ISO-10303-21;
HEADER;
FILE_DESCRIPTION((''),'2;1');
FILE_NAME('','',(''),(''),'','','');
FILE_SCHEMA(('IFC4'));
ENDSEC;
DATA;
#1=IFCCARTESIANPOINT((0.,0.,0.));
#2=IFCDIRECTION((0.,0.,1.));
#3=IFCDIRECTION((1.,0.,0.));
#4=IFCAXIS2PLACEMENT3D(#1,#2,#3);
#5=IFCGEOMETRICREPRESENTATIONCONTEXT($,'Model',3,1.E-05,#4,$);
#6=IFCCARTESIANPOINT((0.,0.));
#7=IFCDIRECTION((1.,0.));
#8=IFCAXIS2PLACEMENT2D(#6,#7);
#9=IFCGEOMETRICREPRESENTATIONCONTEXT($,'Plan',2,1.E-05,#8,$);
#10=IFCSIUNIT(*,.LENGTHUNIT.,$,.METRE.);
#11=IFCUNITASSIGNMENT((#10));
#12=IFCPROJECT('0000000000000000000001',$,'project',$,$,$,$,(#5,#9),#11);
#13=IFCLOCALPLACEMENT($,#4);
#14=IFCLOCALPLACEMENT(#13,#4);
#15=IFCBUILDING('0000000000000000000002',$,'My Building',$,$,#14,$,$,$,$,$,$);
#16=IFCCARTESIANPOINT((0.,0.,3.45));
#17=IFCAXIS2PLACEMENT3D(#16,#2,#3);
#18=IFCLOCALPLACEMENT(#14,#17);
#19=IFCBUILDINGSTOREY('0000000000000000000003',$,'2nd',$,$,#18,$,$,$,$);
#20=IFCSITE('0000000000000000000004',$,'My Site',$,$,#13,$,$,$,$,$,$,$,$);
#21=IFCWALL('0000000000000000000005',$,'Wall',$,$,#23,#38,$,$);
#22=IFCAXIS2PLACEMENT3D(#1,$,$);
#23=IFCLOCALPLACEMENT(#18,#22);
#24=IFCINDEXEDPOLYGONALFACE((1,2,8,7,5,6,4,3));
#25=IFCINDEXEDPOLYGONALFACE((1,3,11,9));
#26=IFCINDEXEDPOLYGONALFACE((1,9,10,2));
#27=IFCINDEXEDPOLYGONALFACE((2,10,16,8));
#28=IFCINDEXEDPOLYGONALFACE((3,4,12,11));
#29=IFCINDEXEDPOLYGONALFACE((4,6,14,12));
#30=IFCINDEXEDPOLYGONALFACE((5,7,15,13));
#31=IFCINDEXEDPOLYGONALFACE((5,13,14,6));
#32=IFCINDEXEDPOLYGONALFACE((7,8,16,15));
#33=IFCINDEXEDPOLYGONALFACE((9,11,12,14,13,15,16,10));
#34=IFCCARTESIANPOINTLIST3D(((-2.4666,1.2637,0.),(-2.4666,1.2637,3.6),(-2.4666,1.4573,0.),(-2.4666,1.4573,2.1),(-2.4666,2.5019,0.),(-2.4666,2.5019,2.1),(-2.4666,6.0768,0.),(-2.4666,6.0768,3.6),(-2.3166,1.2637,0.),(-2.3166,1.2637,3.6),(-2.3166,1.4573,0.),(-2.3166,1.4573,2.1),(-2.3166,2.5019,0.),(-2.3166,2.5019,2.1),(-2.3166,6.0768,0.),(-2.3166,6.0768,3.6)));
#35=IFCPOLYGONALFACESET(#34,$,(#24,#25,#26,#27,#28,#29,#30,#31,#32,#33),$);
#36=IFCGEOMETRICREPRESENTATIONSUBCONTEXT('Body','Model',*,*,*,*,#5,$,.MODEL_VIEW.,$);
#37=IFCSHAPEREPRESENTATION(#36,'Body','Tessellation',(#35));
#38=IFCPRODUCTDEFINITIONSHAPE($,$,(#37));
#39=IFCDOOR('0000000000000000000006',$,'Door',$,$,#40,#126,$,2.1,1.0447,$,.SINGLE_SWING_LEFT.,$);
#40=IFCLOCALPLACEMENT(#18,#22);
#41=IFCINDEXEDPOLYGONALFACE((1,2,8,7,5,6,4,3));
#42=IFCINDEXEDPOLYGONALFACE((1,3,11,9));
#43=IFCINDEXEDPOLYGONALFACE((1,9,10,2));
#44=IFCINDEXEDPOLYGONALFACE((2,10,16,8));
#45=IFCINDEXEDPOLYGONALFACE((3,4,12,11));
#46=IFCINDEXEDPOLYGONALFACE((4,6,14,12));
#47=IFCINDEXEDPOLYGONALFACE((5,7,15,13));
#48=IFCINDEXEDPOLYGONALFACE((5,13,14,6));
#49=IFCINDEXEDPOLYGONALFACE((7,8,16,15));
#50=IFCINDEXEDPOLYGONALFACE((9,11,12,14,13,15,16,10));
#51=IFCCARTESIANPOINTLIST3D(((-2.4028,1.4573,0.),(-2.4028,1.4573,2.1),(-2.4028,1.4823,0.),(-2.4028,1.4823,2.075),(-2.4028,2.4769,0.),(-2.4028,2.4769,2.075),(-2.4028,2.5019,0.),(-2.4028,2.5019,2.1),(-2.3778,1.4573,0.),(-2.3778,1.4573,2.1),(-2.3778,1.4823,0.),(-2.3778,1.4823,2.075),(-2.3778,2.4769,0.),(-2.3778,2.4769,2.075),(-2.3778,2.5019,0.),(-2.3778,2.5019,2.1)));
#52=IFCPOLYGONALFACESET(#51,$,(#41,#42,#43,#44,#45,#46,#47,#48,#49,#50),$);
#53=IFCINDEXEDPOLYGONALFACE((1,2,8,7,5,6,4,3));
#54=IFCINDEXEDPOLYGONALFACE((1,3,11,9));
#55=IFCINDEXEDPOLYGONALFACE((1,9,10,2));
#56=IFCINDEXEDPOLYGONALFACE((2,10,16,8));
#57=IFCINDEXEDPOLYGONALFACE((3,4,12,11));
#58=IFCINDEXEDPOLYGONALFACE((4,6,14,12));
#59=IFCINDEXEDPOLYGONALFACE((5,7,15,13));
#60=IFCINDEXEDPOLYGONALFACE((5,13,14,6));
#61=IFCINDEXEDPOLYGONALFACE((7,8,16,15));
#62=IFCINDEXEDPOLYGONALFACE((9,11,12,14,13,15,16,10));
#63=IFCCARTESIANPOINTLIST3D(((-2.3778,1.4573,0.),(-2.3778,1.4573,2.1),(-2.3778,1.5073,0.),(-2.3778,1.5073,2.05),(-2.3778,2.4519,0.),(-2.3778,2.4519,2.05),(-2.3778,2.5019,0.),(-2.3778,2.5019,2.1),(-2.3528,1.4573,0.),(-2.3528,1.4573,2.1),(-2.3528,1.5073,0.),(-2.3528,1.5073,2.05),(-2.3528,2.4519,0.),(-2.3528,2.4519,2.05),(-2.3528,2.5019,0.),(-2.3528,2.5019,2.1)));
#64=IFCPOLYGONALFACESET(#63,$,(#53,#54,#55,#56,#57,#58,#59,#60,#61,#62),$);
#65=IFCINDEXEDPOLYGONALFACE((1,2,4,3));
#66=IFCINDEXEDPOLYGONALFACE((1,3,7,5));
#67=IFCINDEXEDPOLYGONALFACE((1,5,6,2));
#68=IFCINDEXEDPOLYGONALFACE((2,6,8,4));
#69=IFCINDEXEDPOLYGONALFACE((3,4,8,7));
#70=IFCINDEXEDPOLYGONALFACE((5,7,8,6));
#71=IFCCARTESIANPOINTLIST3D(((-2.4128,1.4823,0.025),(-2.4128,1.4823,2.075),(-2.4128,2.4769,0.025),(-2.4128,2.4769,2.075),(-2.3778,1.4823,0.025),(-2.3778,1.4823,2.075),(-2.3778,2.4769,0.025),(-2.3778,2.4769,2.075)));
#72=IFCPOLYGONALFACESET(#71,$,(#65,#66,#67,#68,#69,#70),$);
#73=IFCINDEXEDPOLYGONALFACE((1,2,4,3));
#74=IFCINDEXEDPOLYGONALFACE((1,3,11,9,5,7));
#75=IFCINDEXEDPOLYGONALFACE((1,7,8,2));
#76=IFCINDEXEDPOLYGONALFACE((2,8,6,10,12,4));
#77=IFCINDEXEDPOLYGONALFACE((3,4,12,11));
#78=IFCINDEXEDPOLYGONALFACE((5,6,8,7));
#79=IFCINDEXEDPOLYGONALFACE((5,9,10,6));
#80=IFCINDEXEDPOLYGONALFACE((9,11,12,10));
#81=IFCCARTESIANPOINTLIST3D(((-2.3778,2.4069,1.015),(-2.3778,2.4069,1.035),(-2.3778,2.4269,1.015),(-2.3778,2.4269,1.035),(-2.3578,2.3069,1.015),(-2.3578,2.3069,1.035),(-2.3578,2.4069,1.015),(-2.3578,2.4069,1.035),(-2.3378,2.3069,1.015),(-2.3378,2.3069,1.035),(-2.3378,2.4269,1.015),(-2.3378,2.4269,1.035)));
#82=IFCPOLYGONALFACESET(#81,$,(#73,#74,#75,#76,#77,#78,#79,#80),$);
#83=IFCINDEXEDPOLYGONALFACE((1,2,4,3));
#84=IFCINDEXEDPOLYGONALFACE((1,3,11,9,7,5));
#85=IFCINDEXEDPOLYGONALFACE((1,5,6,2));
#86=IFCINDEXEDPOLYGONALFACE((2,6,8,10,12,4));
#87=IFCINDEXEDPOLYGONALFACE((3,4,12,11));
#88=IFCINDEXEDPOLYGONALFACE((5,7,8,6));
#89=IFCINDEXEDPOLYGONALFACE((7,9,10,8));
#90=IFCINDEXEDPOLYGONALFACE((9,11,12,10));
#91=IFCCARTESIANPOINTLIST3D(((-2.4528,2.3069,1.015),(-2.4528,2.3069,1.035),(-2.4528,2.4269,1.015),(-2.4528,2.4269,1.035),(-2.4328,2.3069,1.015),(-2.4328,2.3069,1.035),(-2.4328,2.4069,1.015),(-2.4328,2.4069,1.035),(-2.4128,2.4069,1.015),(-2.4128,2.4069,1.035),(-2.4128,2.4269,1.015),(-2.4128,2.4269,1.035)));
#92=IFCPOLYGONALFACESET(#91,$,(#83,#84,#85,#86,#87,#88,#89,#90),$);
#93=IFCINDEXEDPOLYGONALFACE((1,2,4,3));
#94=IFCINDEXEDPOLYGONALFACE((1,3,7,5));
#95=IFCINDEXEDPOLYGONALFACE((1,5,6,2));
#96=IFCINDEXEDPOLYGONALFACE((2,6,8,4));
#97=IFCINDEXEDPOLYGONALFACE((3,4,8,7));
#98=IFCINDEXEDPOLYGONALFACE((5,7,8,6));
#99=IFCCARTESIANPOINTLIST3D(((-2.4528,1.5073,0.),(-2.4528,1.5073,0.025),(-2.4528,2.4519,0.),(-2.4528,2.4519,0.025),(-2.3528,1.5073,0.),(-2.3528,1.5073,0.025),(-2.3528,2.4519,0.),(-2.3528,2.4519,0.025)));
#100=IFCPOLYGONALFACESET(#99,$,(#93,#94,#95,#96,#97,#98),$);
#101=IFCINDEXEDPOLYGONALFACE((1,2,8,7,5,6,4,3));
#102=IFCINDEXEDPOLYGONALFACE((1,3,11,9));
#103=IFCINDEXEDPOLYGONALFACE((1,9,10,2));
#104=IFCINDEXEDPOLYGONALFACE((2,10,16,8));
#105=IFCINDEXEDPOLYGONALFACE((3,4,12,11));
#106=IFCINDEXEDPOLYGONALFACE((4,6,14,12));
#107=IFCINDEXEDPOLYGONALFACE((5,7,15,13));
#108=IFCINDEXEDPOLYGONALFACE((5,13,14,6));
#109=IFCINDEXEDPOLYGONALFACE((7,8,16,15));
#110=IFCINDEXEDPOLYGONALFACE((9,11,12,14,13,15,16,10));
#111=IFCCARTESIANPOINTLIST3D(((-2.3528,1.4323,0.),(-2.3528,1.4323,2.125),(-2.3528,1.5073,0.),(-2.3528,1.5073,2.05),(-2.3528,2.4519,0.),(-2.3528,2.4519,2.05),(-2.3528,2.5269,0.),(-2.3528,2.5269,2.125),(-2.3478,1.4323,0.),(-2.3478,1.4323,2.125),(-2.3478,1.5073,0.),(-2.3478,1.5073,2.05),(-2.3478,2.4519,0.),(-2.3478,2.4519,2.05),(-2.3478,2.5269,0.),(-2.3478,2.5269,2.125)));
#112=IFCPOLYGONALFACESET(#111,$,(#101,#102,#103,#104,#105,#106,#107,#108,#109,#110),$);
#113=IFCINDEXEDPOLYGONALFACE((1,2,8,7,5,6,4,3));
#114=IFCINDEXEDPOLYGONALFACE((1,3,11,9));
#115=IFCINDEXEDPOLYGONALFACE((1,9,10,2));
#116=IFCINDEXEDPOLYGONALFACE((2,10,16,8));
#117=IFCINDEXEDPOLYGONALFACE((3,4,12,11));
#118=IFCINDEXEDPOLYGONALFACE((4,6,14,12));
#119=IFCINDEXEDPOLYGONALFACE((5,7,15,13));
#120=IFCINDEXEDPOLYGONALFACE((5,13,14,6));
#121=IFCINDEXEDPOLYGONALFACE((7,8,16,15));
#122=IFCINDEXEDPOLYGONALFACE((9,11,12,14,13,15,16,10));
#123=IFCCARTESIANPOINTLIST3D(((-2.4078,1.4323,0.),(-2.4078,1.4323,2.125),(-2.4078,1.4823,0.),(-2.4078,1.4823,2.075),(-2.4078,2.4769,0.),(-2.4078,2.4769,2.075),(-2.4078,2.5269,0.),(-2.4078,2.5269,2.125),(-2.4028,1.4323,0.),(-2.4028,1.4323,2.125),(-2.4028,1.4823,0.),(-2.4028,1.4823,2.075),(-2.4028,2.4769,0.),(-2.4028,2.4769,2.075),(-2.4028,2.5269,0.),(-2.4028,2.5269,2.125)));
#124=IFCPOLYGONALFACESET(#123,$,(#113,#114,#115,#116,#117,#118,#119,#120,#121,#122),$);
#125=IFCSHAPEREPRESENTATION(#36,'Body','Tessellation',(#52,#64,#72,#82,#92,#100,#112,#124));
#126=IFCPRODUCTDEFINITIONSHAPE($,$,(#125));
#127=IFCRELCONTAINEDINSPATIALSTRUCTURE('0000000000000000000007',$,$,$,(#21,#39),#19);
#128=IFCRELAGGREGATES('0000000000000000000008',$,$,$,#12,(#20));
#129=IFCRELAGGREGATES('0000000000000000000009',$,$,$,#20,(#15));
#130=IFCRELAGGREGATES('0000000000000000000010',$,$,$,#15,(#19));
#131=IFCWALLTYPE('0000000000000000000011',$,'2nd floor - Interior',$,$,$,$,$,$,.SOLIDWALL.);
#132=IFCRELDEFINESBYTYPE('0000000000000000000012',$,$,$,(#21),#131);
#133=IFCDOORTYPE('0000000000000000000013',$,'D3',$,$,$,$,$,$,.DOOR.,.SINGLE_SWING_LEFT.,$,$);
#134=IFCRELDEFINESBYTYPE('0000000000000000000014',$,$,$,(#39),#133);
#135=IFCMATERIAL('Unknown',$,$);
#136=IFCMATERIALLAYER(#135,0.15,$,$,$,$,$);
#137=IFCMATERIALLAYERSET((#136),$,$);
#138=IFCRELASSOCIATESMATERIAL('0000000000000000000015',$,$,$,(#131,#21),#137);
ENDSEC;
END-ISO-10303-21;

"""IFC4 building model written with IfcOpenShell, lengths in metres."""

from ifc_helpers import new_model, entity, si_unit, frame, origin_with_axes, origin_2d_with_axis, place, context, subcontext, project, spatial, line, indexed_curve, outline, extrude, shape, source, transform, mapped, material, layer, layer_set, layer_usage, type_object, type_shapes, element, fill, save


model = new_model("IFC4")

# Units and contexts
model_context = context("Model", 3, precision=1e-05, world=origin_with_axes())
plan_context = context("Plan", 2, precision=1e-05, world=origin_2d_with_axis())
body_context_1 = subcontext(model_context, "Body", "Model", "MODEL_VIEW")
body_context_2 = subcontext(plan_context, "Body", "Plan", "PLAN_VIEW")
ifc_project = project(units=[si_unit("LENGTHUNIT", "METRE")], contexts=[model_context, plan_context])

# Site, building, storey
site_placement = place(None, origin_with_axes())
site = spatial("IfcSite", under=ifc_project, at=site_placement, Name="My Site")
building_placement = place(site_placement, origin_with_axes())
building = spatial("IfcBuilding", under=site, at=building_placement, Name="My Building")
storey_placement = place(building_placement, frame((0.0, 0.0, 3.45), z_axis=(0.0, 0.0, 1.0), x_axis=(1.0, 0.0, 0.0)))
storey = spatial("IfcBuildingStorey", under=building, at=storey_placement, Name="2nd")

# Shared definitions
ifc_material = material(Name="Unknown")

# Wall, opening, door
ifc_layer_1 = layer(ifc_material, 0.15)
ifc_layer_set_1 = layer_set([ifc_layer_1])
wall_type_1 = type_object("IfcWallType", Name="2nd floor - Interior", PredefinedType="SOLIDWALL", material=ifc_layer_set_1)
ifc_layer_usage_1 = layer_usage(ifc_layer_set_1, "AXIS2", "POSITIVE", 0.0)
wall_1_placement = place(storey_placement, frame((-2.4666, 6.2768, 0.0), z_axis=(0.0, 0.0, 1.0), x_axis=(0.0, -1.0, 0.0)))
wall_1 = element("IfcWall", 1, at=wall_1_placement, inside=storey, type_object=wall_type_1, material=ifc_layer_usage_1, Name="Wall", context=body_context_1, shape_type="SweptSolid", body=[
    extrude(outline(indexed_curve([(0.2, 0.0), (0.2, 0.15), (5.0131, 0.15), (5.0131, 0.0)], segments=[line(1, 2, 3, 4, 1)])), origin_with_axes(), (0.0, 0.0, 1.0), 3.6),
])
shared_shape_1 = source(origin_with_axes(), body_context_1, "Body", "SweptSolid", [
    extrude(outline(indexed_curve([(0.0, 0.0), (1.0447, 0.0), (1.0447, 2.1), (0.0, 2.1)], segments=[line(1, 2, 3, 4, 1)])), frame((0.0, -0.6, 0.0), z_axis=(0.0, -1.0, 0.0), x_axis=(1.0, 0.0, 0.0)), (0.0, 0.0, -1.0), 1.2),
])
opening_1_placement = place(wall_1_placement, frame((4.8195, 0.1139, 0.0), z_axis=(0.0, 0.0, 1.0), x_axis=(-1.0, 0.0, 0.0)))
opening_1 = element("IfcOpeningElement", 2, at=opening_1_placement, cuts=wall_1, PredefinedType="OPENING", context=body_context_1, shape_type="MappedRepresentation", body=[
    mapped(shared_shape_1, transform((0.0, 0.0, 0.0), x_axis=(1.0, 0.0, 0.0), y_axis=(0.0, 1.0, 0.0), z_axis=(0.0, 0.0, 1.0), scale=1.0)),
])
door_type_1 = type_object("IfcDoorType", Name="D3", OperationType="SINGLE_SWING_LEFT", PredefinedType="DOOR")
shared_shape_2 = source(origin_with_axes(), body_context_1, "Body", "SweptSolid", [
    extrude(outline(indexed_curve([(0.0, 0.0), (0.0, 2.1), (1.0447, 2.1), (1.0447, 0.0), (1.0197, 0.0), (1.0197, 2.075), (0.025, 2.075), (0.025, 0.0)], segments=[line(1, 2, 3, 4, 5, 6, 7, 8, 1)])), frame((0.0, 0.025, 0.0), z_axis=(0.0, -1.0, 0.0), x_axis=(1.0, 0.0, 0.0)), (0.0, 0.0, -1.0), 0.025),
    extrude(outline(indexed_curve([(0.0, 0.0), (0.0, 2.1), (1.0447, 2.1), (1.0447, 0.0), (0.9947, 0.0), (0.9947, 2.05), (0.05, 2.05), (0.05, 0.0)], segments=[line(1, 2, 3, 4, 5, 6, 7, 8, 1)])), frame((0.0, 0.0, 0.0), z_axis=(0.0, -1.0, 0.0), x_axis=(1.0, 0.0, 0.0)), (0.0, 0.0, -1.0), 0.025),
    extrude(outline(indexed_curve([(0.0, 0.0), (0.9947, 0.0), (0.9947, 0.035), (0.0, 0.035)], segments=[line(1, 2, 3, 4, 1)])), frame((0.025, 0.025, 0.025), z_axis=(0.0, 0.0, 1.0), x_axis=(1.0, 0.0, 0.0)), (0.0, 0.0, 1.0), 2.05),
    extrude(outline(indexed_curve([(0.0, 0.0), (0.0, -0.04), (-0.12, -0.04), (-0.12, -0.02), (-0.02, -0.02), (-0.02, 0.0)], segments=[line(1, 2, 3, 4, 5, 6, 1)])), frame((0.9697, 0.025, 1.015), z_axis=(0.0, 0.0, 1.0), x_axis=(1.0, 0.0, 0.0)), (0.0, 0.0, 1.0), 0.02),
    extrude(outline(indexed_curve([(0.0, 0.0), (0.0, 0.04), (-0.12, 0.04), (-0.12, 0.02), (-0.02, 0.02), (-0.02, 0.0)], segments=[line(1, 2, 3, 4, 5, 6, 1)])), frame((0.9697, 0.06, 1.015), z_axis=(0.0, 0.0, 1.0), x_axis=(1.0, 0.0, 0.0)), (0.0, 0.0, 1.0), 0.02),
    extrude(outline(indexed_curve([(0.0, 0.0), (0.9447, 0.0), (0.9447, 0.1), (0.0, 0.1)], segments=[line(1, 2, 3, 4, 1)])), frame((0.05, 0.0, 0.0), z_axis=(0.0, 0.0, 1.0), x_axis=(1.0, 0.0, 0.0)), (0.0, 0.0, 1.0), 0.025),
    extrude(outline(indexed_curve([(0.0, 0.0), (0.0, 2.125), (1.0947, 2.125), (1.0947, 0.0), (1.0197, 0.0), (1.0197, 2.05), (0.075, 2.05), (0.075, 0.0)], segments=[line(1, 2, 3, 4, 5, 6, 7, 8, 1)])), frame((-0.025, -0.005, 0.0), z_axis=(0.0, -1.0, 0.0), x_axis=(1.0, 0.0, 0.0)), (0.0, 0.0, -1.0), 0.005),
    extrude(outline(indexed_curve([(0.0, 0.0), (0.0, 2.125), (1.0947, 2.125), (1.0947, 0.0), (1.0447, 0.0), (1.0447, 2.075), (0.05, 2.075), (0.05, 0.0)], segments=[line(1, 2, 3, 4, 5, 6, 7, 8, 1)])), frame((-0.025, 0.05, 0.0), z_axis=(0.0, -1.0, 0.0), x_axis=(1.0, 0.0, 0.0)), (0.0, 0.0, -1.0), 0.005),
])
shared_shape_3 = source(origin_with_axes(), body_context_2, "Body", "Curve2D", [
    entity("IfcIndexedPolyCurve", entity("IfcCartesianPointList2D", [[0.0, 0.0], [0.0, 0.05], [0.025, 0.05], [0.025, 0.025], [0.05, 0.025], [0.05, 0.0]]), [entity("IfcLineIndex", [1, 2, 3, 4, 5, 6, 1])]),
    entity("IfcIndexedPolyCurve", entity("IfcCartesianPointList2D", [[1.0447, 0.0], [1.0447, 0.05], [1.0197, 0.05], [1.0197, 0.025], [0.9947, 0.025], [0.9947, 0.0]]), [entity("IfcLineIndex", [1, 2, 3, 4, 5, 6, 1])]),
    entity("IfcTrimmedCurve", entity("IfcEllipse", entity("IfcAxis2Placement2D", entity("IfcCartesianPoint", [0.06, 0.05]), entity("IfcDirection", [1.0, 0.0])), 0.9597, 0.9947), [entity("IfcCartesianPoint", [1.0197, 0.05])], [entity("IfcCartesianPoint", [0.06, 1.0447])], True, "CARTESIAN"),
    entity("IfcIndexedPolyCurve", entity("IfcCartesianPointList2D", [[0.025, 0.05], [0.06, 0.05], [0.06, 1.0447], [0.025, 1.0447]]), [entity("IfcLineIndex", [1, 2, 3, 4, 1])]),
])
type_shapes(door_type_1, [shared_shape_2, shared_shape_3])
door_1_placement = place(opening_1_placement, frame((0.0, 0.0, 0.0), z_axis=(0.0, 0.0, 1.0), x_axis=(1.0, 0.0, 0.0)))
door_1 = element("IfcDoor", 3, at=door_1_placement, inside=storey, type_object=door_type_1, Name="Door", OperationType="SINGLE_SWING_LEFT", OverallHeight=2.1, OverallWidth=1.0447, shapes=[
    shape(body_context_1, "Body", "MappedRepresentation", [mapped(shared_shape_2, transform((0.0, 0.0, 0.0), x_axis=(1.0, 0.0, 0.0), y_axis=(0.0, 1.0, 0.0), z_axis=(0.0, 0.0, 1.0), scale=1.0))]),
    shape(body_context_2, "Body", "MappedRepresentation", [mapped(shared_shape_3, transform((0.0, 0.0, 0.0), x_axis=(1.0, 0.0, 0.0), y_axis=(0.0, 1.0, 0.0), z_axis=(0.0, 0.0, 1.0), scale=1.0))]),
])
fill(opening_1, door_1)

save(model, "model.ifc")
